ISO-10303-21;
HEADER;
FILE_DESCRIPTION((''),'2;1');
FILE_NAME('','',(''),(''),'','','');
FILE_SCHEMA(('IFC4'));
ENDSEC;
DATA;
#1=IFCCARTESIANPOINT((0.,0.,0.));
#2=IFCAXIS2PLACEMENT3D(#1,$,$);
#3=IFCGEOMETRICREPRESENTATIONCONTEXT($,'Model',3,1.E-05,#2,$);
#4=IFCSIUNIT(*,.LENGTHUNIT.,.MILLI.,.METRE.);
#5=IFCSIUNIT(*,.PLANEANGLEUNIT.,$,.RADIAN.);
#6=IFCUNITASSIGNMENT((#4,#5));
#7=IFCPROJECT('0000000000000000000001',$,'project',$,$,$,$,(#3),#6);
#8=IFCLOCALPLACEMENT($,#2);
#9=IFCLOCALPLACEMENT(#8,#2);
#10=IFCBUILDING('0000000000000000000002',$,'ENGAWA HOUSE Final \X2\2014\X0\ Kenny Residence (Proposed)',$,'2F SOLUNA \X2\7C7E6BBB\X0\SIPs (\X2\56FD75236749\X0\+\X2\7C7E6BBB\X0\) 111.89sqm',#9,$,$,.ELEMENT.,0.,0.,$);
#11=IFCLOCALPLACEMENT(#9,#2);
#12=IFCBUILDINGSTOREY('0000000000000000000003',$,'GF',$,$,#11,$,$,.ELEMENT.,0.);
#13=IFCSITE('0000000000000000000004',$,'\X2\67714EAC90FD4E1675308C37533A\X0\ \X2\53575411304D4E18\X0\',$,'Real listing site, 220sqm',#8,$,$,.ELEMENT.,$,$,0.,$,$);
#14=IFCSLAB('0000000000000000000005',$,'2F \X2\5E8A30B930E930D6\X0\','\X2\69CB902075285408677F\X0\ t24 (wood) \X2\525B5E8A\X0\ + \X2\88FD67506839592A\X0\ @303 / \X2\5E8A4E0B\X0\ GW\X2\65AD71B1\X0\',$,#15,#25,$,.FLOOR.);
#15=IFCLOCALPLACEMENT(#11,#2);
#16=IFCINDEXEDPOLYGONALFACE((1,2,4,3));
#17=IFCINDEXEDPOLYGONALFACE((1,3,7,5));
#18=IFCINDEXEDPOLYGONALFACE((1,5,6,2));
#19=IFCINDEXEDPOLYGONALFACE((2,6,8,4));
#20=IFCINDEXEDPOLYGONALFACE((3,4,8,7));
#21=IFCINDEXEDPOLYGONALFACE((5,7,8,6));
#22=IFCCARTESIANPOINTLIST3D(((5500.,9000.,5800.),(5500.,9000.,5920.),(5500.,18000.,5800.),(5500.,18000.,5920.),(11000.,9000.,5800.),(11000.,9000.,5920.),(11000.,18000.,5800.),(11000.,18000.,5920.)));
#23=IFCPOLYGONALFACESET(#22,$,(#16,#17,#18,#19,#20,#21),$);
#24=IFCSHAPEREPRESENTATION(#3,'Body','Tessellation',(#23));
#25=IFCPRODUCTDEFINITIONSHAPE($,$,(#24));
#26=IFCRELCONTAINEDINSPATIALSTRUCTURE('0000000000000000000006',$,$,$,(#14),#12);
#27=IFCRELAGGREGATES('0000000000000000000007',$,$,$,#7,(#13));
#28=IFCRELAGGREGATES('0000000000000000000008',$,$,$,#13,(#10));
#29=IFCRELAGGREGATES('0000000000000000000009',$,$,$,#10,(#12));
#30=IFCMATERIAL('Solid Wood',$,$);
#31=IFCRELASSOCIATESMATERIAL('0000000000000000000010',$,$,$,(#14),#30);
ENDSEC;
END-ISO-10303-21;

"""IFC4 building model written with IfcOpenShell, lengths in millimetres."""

from ifc_helpers import new_model, si_unit, frame, frame_2d, origin, place, context, project, spatial, rectangle, extrude, material, element, save


model = new_model("IFC4")

# Units and contexts
model_context = context("Model", 3, precision=1e-05, world=origin())
ifc_project = project(units=[si_unit("LENGTHUNIT", "METRE", prefix="MILLI"), si_unit("PLANEANGLEUNIT", "RADIAN")], contexts=[model_context])

# Site, building, storey
site_placement = place(None, origin())
site = spatial("IfcSite", under=ifc_project, at=site_placement, Name="東京都世田谷区 南向き丘", ObjectType="Real listing site, 220sqm", CompositionType="ELEMENT", RefElevation=0.0)
building_placement = place(site_placement, origin())
building = spatial("IfcBuilding", under=site, at=building_placement, Name="ENGAWA HOUSE Final — Kenny Residence (Proposed)", ObjectType="2F SOLUNA 籾殻SIPs (国産杉+籾殻) 111.89sqm", CompositionType="ELEMENT", ElevationOfRefHeight=0.0, ElevationOfTerrain=0.0)
storey_placement = place(building_placement, origin())
storey = spatial("IfcBuildingStorey", under=building, at=storey_placement, Name="GF", CompositionType="ELEMENT", Elevation=0.0)

# Slab
ifc_material_1 = material(Name="Solid Wood")
slab_placement = place(storey_placement, frame((2750.0, 4500.0, 2900.0)))
element("IfcSlab", 1, at=slab_placement, inside=storey, material=ifc_material_1, Name="2F 床スラブ", Description="構造用合板 t24 (wood) 剛床 + 製材根太 @303 / 床下 GW断熱", PredefinedType="FLOOR", context=model_context, shape_type="SweptSolid", body=[
    extrude(rectangle(XDim=5500.0, YDim=9000.0, at=frame_2d((2750.0, 4500.0))), frame((2750.0, 4500.0, 2900.0)), (0.0, 0.0, 1.0), 120.0),
])

save(model, "model.ifc")
